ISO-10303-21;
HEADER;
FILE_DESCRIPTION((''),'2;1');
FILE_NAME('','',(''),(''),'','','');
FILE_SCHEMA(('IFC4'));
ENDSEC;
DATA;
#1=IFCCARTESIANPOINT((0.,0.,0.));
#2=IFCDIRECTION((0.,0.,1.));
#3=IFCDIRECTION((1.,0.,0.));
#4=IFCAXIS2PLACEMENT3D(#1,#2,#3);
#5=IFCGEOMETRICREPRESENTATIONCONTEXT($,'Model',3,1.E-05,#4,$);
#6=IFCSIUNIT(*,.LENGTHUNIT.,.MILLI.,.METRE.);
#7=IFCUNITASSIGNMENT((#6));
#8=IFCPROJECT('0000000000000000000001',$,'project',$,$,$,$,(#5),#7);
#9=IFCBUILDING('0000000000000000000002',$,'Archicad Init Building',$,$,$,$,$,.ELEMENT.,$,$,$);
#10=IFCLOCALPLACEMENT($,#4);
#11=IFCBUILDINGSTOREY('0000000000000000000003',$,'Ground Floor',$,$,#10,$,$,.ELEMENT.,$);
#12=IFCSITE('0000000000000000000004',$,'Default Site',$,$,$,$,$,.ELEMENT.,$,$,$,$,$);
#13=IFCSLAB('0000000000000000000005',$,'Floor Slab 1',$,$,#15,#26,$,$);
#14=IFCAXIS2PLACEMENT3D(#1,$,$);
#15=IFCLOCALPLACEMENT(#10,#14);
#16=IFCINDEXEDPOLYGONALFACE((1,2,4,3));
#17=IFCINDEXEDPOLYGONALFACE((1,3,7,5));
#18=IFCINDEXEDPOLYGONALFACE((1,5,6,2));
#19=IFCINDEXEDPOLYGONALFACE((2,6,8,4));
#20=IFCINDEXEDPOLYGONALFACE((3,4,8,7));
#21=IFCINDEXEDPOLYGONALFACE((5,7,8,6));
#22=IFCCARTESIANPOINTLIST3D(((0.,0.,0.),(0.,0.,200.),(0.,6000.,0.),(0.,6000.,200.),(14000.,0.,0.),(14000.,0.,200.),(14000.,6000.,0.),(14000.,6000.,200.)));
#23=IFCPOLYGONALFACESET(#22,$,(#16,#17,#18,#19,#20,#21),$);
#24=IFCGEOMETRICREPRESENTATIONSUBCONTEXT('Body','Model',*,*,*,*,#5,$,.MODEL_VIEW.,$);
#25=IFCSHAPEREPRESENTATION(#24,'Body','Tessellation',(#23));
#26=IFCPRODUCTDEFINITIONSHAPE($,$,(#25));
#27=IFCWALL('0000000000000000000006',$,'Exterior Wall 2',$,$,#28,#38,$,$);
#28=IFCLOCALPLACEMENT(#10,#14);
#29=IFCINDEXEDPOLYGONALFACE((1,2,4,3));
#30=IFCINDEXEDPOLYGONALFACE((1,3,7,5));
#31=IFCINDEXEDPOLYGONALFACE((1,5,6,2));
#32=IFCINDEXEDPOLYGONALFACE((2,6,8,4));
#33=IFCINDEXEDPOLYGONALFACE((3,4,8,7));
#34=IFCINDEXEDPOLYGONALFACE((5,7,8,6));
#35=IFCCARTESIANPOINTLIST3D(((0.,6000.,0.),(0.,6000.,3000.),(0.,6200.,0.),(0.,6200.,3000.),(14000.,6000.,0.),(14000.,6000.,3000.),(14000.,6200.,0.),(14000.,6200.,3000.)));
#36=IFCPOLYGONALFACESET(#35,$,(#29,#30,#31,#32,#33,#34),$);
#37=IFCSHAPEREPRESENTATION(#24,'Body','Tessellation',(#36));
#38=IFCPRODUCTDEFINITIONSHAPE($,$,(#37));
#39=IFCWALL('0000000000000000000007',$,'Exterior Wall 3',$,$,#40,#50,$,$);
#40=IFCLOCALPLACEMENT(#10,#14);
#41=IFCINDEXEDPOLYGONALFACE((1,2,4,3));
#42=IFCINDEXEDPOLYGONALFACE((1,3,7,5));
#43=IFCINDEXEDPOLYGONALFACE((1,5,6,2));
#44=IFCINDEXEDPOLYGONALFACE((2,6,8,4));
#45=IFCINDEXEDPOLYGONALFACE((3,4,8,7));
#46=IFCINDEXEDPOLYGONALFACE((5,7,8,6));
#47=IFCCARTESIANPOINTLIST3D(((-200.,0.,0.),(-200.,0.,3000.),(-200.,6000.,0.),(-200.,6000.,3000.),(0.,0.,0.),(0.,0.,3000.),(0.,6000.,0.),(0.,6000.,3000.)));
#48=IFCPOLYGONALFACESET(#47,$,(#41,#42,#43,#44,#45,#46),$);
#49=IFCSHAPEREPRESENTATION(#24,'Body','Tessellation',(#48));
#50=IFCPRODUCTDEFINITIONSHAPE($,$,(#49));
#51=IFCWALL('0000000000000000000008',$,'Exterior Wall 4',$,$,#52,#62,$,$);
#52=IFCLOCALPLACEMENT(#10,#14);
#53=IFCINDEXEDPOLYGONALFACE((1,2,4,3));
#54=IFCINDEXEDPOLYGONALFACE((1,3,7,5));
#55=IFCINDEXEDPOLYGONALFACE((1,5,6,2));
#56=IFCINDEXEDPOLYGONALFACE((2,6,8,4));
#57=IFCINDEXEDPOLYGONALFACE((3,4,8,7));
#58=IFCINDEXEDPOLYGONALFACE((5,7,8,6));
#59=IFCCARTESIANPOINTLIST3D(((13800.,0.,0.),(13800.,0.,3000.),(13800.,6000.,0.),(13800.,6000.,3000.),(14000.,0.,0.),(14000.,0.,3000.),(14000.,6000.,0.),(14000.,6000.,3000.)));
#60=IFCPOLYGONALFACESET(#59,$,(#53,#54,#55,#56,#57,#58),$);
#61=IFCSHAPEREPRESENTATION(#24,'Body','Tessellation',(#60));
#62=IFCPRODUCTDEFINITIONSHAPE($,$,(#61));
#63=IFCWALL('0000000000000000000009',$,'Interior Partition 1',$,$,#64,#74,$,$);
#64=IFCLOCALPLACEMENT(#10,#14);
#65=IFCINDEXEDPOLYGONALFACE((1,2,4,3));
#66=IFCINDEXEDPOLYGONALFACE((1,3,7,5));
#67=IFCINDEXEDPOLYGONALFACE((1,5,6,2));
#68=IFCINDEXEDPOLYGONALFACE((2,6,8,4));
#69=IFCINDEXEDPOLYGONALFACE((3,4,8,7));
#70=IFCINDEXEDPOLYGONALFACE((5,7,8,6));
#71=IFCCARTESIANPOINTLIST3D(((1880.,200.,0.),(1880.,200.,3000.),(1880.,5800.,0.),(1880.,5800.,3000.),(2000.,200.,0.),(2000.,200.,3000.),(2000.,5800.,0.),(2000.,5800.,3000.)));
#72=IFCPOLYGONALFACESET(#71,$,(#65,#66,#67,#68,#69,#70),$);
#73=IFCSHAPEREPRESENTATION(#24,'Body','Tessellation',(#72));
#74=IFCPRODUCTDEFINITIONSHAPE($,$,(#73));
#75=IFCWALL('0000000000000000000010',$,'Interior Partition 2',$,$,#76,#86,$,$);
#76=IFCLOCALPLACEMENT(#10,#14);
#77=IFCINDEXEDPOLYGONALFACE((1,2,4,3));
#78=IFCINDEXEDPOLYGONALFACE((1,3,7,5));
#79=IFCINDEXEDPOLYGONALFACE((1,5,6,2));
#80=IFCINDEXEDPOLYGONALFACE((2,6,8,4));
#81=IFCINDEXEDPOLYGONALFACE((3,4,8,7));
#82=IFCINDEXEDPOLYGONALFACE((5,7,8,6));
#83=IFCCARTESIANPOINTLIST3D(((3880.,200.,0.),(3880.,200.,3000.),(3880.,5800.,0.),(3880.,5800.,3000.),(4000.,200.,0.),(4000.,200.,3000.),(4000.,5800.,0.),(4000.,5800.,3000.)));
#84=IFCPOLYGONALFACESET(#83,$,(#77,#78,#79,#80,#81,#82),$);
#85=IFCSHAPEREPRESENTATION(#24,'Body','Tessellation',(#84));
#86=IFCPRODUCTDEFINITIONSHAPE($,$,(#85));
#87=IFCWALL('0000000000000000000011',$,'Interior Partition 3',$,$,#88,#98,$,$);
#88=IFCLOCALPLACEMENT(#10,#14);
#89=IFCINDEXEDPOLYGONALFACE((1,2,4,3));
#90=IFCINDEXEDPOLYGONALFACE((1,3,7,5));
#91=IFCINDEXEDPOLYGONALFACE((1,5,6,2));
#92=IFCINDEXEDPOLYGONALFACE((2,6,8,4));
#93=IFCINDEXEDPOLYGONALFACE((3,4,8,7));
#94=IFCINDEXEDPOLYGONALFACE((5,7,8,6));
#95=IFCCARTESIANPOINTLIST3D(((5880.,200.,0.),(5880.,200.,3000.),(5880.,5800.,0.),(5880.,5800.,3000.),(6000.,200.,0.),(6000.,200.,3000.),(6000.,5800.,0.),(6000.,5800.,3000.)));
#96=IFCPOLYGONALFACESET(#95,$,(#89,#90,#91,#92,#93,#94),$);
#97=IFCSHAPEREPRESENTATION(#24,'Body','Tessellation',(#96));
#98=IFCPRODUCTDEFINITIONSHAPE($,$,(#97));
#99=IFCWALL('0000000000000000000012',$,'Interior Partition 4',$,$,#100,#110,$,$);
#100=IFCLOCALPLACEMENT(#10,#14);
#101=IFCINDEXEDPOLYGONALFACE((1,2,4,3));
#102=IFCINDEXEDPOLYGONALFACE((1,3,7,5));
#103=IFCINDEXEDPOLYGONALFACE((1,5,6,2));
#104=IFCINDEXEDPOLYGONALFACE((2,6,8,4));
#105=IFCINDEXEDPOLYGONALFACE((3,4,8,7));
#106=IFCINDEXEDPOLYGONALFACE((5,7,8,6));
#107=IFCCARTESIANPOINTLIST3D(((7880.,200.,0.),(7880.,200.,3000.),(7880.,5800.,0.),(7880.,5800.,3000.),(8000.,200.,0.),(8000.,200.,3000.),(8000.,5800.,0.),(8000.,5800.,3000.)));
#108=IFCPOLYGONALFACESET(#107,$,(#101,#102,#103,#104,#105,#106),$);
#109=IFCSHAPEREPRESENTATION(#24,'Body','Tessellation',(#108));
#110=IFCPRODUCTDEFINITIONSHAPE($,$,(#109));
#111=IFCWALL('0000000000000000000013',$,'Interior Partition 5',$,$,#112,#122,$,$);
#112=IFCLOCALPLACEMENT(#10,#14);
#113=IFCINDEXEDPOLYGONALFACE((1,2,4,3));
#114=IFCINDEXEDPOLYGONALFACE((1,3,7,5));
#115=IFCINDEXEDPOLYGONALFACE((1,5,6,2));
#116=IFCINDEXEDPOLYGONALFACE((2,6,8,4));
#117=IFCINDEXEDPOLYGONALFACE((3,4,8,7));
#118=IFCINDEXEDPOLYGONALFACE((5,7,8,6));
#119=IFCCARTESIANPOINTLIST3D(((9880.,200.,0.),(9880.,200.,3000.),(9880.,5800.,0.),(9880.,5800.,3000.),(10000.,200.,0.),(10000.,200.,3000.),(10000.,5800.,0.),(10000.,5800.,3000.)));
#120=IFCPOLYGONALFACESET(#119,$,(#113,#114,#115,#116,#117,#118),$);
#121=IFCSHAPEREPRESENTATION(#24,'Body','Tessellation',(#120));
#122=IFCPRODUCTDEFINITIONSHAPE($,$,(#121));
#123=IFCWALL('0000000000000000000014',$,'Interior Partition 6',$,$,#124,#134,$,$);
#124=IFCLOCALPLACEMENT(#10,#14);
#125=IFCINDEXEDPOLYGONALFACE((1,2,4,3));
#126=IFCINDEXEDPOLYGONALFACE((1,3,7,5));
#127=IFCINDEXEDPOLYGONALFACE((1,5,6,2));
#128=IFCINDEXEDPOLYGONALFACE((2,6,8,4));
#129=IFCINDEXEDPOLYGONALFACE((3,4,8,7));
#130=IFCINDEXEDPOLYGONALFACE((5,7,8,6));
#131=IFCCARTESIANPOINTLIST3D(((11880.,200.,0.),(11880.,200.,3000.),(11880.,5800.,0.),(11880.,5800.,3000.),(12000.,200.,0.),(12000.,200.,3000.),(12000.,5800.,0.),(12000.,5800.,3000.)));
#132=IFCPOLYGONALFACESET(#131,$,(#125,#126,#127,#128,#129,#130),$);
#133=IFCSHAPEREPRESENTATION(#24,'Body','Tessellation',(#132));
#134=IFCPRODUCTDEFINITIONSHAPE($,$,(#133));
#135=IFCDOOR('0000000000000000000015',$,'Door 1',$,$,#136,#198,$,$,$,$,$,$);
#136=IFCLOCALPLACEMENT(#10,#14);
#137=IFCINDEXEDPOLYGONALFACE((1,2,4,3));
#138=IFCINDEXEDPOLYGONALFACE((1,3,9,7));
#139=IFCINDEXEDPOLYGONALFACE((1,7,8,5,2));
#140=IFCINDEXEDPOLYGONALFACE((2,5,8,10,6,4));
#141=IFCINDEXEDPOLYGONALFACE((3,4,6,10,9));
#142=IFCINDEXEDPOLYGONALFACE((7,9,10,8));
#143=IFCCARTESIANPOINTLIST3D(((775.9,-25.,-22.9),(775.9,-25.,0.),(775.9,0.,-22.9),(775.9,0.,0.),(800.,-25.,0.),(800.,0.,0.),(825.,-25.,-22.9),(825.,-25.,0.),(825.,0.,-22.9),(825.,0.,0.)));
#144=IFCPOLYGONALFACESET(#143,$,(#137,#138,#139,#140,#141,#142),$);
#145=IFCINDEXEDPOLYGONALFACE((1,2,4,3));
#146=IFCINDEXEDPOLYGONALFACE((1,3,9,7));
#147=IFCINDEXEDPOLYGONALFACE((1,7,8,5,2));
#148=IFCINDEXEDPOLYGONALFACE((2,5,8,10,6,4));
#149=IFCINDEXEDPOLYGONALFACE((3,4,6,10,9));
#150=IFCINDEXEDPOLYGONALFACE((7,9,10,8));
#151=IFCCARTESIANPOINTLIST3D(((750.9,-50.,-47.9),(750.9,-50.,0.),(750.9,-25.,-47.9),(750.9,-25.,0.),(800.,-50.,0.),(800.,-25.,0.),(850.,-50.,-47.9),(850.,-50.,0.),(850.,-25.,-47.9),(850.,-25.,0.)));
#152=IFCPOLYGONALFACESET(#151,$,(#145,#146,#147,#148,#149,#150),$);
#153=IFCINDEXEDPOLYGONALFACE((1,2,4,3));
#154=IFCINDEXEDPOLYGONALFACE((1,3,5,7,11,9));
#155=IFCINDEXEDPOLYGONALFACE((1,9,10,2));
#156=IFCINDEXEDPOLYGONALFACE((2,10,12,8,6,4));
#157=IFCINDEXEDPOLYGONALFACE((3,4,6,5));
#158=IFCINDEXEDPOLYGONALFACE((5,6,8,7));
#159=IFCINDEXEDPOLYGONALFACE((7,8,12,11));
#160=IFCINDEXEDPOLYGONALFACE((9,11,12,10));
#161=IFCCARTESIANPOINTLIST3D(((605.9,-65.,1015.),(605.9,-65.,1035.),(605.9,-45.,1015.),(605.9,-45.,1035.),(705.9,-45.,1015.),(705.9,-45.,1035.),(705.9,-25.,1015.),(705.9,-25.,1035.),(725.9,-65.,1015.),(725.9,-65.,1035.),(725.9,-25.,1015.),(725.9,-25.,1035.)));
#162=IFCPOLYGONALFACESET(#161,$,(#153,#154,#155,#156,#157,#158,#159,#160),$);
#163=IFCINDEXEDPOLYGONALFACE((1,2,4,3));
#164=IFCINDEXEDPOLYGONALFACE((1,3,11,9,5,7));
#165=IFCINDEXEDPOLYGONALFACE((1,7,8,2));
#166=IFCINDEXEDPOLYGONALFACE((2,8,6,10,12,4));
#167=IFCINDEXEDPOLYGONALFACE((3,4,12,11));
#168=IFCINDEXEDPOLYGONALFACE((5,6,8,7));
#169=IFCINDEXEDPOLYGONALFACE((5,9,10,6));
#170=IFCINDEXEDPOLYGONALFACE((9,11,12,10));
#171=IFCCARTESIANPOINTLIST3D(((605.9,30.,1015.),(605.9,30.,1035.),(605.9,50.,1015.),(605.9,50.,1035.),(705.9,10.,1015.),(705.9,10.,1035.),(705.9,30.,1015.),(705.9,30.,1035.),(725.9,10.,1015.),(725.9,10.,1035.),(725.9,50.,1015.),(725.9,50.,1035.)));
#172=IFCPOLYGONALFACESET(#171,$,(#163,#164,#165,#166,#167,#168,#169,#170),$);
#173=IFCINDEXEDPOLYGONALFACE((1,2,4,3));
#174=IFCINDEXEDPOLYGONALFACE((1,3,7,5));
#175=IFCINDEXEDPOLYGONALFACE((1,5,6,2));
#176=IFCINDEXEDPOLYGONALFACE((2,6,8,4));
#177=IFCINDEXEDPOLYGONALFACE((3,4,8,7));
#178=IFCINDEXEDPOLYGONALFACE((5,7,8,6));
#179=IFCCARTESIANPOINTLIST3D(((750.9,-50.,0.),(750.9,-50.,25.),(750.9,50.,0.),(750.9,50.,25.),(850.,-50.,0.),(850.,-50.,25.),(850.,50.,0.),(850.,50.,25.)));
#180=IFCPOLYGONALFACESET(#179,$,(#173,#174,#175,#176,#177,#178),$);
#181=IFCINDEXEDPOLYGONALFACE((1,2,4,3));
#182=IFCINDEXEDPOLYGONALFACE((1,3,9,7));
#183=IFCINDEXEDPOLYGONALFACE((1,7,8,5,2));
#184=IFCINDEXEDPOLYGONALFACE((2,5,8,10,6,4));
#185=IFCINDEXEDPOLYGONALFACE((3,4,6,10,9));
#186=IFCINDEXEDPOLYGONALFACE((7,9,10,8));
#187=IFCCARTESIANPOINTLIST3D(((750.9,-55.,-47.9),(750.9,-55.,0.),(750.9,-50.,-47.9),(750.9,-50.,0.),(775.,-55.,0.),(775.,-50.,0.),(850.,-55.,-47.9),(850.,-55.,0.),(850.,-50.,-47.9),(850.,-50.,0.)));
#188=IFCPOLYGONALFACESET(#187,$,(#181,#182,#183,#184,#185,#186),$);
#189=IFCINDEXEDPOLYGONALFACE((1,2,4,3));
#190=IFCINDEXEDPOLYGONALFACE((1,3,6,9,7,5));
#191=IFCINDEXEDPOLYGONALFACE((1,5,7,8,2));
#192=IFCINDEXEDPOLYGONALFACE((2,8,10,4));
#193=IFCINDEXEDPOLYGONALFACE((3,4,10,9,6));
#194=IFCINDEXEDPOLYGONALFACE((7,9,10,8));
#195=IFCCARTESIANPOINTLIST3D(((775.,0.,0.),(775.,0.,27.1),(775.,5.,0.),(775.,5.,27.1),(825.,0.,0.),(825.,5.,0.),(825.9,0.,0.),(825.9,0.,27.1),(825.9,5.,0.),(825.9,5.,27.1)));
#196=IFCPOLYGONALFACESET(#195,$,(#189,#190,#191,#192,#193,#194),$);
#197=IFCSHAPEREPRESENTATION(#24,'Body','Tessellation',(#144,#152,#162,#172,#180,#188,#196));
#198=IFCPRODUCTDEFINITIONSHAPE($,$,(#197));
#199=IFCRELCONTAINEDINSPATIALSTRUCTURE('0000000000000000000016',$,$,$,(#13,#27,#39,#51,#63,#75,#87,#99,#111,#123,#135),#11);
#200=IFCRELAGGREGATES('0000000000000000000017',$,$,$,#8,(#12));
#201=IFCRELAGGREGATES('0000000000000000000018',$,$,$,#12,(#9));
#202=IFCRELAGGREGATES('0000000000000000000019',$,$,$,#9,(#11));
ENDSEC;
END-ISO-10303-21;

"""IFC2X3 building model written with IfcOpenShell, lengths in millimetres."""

from ifc_helpers import new_model, si_unit, frame, origin_with_axes, place, context, subcontext, project, spatial, polyline, outline, extrude, element, save


model = new_model("IFC2X3")

# Units and contexts
model_context = context("Model", 3, precision=1e-05, world=origin_with_axes())
body_context = subcontext(model_context, "Body", "Model", "MODEL_VIEW")
ifc_project = project(units=[si_unit("LENGTHUNIT", "METRE", prefix="MILLI")], contexts=[model_context])

# Site, building, storey
site = spatial("IfcSite", under=ifc_project, Name="Default Site", CompositionType="ELEMENT")
building = spatial("IfcBuilding", under=site, Name="Archicad Init Building", CompositionType="ELEMENT")
storey_placement = place(None, origin_with_axes())
storey = spatial("IfcBuildingStorey", under=building, at=storey_placement, Name="Ground Floor", CompositionType="ELEMENT")

# Slab
slab_placement = place(storey_placement, origin_with_axes())
element("IfcSlab", 1, at=slab_placement, inside=storey, Name="Floor Slab 1", context=body_context, shape_type="SweptSolid", body=[
    extrude(outline(polyline([(0.0, 0.0), (14000.0, 0.0), (14000.0, 6000.0), (0.0, 6000.0), (0.0, 0.0)])), origin_with_axes(), (0.0, 0.0, 1.0), 200.0),
])

# Walls
wall_placement = place(storey_placement, frame((0.0, 6000.0, 0.0), z_axis=(0.0, 0.0, 1.0), x_axis=(1.0, 0.0, 0.0)))
element("IfcWall", 2, at=wall_placement, inside=storey, Name="Exterior Wall 2", context=body_context, shape_type="SweptSolid", body=[
    extrude(outline(polyline([(0.0, 0.0), (0.0, 200.0), (14000.0, 200.0), (14000.0, 0.0), (0.0, 0.0)])), origin_with_axes(), (0.0, 0.0, 1.0), 3000.0),
])
for number, where, z_axis, x_axis, name in (
    (3, (0.0, 0.0, 0.0), (0.0, 0.0, 1.0), (0.0, 1.0, 0.0), "Exterior Wall 3"),
    (4, (14000.0, 0.0, 0.0), (0.0, 0.0, 1.0), (0.0, 1.0, 0.0), "Exterior Wall 4"),
):
    element("IfcWall", number, at=place(storey_placement, frame(where, z_axis=z_axis, x_axis=x_axis)), inside=storey, Name=name, context=body_context, shape_type="SweptSolid", body=[
        extrude(outline(polyline([(0.0, 0.0), (0.0, 200.0), (6000.0, 200.0), (6000.0, 0.0), (0.0, 0.0)])), origin_with_axes(), (0.0, 0.0, 1.0), 3000.0),
    ])
for number, where, z_axis, x_axis, name in (
    (5, (2000.0, 200.0, 0.0), (0.0, 0.0, 1.0), (0.0, 1.0, 0.0), "Interior Partition 1"),
    (6, (4000.0, 200.0, 0.0), (0.0, 0.0, 1.0), (0.0, 1.0, 0.0), "Interior Partition 2"),
    (7, (6000.0, 200.0, 0.0), (0.0, 0.0, 1.0), (0.0, 1.0, 0.0), "Interior Partition 3"),
    (8, (8000.0, 200.0, 0.0), (0.0, 0.0, 1.0), (0.0, 1.0, 0.0), "Interior Partition 4"),
    (9, (10000.0, 200.0, 0.0), (0.0, 0.0, 1.0), (0.0, 1.0, 0.0), "Interior Partition 5"),
    (10, (12000.0, 200.0, 0.0), (0.0, 0.0, 1.0), (0.0, 1.0, 0.0), "Interior Partition 6"),
):
    element("IfcWall", number, at=place(storey_placement, frame(where, z_axis=z_axis, x_axis=x_axis)), inside=storey, Name=name, context=body_context, shape_type="SweptSolid", body=[
        extrude(outline(polyline([(0.0, 0.0), (0.0, 120.0), (5600.0, 120.0), (5600.0, 0.0), (0.0, 0.0)])), origin_with_axes(), (0.0, 0.0, 1.0), 3000.0),
    ])

# Door
door_1_placement = place(storey_placement, frame((800.0, -50.0, 0.0), z_axis=(0.0, 0.0, 1.0), x_axis=(1.0, 0.0, 0.0)))
element("IfcDoor", 11, at=door_1_placement, inside=storey, Name="Door 1", context=body_context, shape_type="SweptSolid", body=[
    extrude(outline(polyline([(0.0, 0.0), (0.0, 2.1), (0.9, 2.1), (0.9, 0.0), (-24.1, 0.0), (-24.1, -22.9), (25.0, -22.9), (25.0, 0.0), (0.0, 0.0)])), frame((0.0, 25.0, 0.0), z_axis=(0.0, -1.0, 0.0), x_axis=(1.0, 0.0, 0.0)), (0.0, 0.0, -1.0), 25.0),
    extrude(outline(polyline([(0.0, 0.0), (0.0, 2.1), (0.9, 2.1), (0.9, 0.0), (-49.1, 0.0), (-49.1, -47.9), (50.0, -47.9), (50.0, 0.0), (0.0, 0.0)])), frame((0.0, 0.0, 0.0), z_axis=(0.0, -1.0, 0.0), x_axis=(1.0, 0.0, 0.0)), (0.0, 0.0, -1.0), 25.0),
    extrude(outline(polyline([(0.0, 0.0), (-49.1, 0.0), (-49.1, 35.0), (0.0, 35.0), (0.0, 0.0)])), frame((25.0, 25.0, 25.0), z_axis=(0.0, 0.0, 1.0), x_axis=(1.0, 0.0, 0.0)), (0.0, 0.0, 1.0), -47.9),
    extrude(outline(polyline([(0.0, 0.0), (0.0, -40.0), (-120.0, -40.0), (-120.0, -20.0), (-20.0, -20.0), (-20.0, 0.0), (0.0, 0.0)])), frame((-74.1, 25.0, 1015.0), z_axis=(0.0, 0.0, 1.0), x_axis=(1.0, 0.0, 0.0)), (0.0, 0.0, 1.0), 20.0),
    extrude(outline(polyline([(0.0, 0.0), (0.0, 40.0), (-120.0, 40.0), (-120.0, 20.0), (-20.0, 20.0), (-20.0, 0.0), (0.0, 0.0)])), frame((-74.1, 60.0, 1015.0), z_axis=(0.0, 0.0, 1.0), x_axis=(1.0, 0.0, 0.0)), (0.0, 0.0, 1.0), 20.0),
    extrude(outline(polyline([(0.0, 0.0), (-99.1, 0.0), (-99.1, 100.0), (0.0, 100.0), (0.0, 0.0)])), frame((50.0, 0.0, 0.0), z_axis=(0.0, 0.0, 1.0), x_axis=(1.0, 0.0, 0.0)), (0.0, 0.0, 1.0), 25.0),
    extrude(outline(polyline([(0.0, 0.0), (0.0, 27.1), (50.9, 27.1), (50.9, 0.0), (-24.1, 0.0), (-24.1, -47.9), (75.0, -47.9), (75.0, 0.0), (0.0, 0.0)])), frame((-25.0, -5.0, 0.0), z_axis=(0.0, -1.0, 0.0), x_axis=(1.0, 0.0, 0.0)), (0.0, 0.0, -1.0), 5.0),
    extrude(outline(polyline([(0.0, 0.0), (0.0, 27.1), (50.9, 27.1), (50.9, 0.0), (0.9, 0.0), (0.9, -22.9), (50.0, -22.9), (50.0, 0.0), (0.0, 0.0)])), frame((-25.0, 50.0, 0.0), z_axis=(0.0, -1.0, 0.0), x_axis=(1.0, 0.0, 0.0)), (0.0, 0.0, -1.0), 5.0),
])

save(model, "model.ifc")
